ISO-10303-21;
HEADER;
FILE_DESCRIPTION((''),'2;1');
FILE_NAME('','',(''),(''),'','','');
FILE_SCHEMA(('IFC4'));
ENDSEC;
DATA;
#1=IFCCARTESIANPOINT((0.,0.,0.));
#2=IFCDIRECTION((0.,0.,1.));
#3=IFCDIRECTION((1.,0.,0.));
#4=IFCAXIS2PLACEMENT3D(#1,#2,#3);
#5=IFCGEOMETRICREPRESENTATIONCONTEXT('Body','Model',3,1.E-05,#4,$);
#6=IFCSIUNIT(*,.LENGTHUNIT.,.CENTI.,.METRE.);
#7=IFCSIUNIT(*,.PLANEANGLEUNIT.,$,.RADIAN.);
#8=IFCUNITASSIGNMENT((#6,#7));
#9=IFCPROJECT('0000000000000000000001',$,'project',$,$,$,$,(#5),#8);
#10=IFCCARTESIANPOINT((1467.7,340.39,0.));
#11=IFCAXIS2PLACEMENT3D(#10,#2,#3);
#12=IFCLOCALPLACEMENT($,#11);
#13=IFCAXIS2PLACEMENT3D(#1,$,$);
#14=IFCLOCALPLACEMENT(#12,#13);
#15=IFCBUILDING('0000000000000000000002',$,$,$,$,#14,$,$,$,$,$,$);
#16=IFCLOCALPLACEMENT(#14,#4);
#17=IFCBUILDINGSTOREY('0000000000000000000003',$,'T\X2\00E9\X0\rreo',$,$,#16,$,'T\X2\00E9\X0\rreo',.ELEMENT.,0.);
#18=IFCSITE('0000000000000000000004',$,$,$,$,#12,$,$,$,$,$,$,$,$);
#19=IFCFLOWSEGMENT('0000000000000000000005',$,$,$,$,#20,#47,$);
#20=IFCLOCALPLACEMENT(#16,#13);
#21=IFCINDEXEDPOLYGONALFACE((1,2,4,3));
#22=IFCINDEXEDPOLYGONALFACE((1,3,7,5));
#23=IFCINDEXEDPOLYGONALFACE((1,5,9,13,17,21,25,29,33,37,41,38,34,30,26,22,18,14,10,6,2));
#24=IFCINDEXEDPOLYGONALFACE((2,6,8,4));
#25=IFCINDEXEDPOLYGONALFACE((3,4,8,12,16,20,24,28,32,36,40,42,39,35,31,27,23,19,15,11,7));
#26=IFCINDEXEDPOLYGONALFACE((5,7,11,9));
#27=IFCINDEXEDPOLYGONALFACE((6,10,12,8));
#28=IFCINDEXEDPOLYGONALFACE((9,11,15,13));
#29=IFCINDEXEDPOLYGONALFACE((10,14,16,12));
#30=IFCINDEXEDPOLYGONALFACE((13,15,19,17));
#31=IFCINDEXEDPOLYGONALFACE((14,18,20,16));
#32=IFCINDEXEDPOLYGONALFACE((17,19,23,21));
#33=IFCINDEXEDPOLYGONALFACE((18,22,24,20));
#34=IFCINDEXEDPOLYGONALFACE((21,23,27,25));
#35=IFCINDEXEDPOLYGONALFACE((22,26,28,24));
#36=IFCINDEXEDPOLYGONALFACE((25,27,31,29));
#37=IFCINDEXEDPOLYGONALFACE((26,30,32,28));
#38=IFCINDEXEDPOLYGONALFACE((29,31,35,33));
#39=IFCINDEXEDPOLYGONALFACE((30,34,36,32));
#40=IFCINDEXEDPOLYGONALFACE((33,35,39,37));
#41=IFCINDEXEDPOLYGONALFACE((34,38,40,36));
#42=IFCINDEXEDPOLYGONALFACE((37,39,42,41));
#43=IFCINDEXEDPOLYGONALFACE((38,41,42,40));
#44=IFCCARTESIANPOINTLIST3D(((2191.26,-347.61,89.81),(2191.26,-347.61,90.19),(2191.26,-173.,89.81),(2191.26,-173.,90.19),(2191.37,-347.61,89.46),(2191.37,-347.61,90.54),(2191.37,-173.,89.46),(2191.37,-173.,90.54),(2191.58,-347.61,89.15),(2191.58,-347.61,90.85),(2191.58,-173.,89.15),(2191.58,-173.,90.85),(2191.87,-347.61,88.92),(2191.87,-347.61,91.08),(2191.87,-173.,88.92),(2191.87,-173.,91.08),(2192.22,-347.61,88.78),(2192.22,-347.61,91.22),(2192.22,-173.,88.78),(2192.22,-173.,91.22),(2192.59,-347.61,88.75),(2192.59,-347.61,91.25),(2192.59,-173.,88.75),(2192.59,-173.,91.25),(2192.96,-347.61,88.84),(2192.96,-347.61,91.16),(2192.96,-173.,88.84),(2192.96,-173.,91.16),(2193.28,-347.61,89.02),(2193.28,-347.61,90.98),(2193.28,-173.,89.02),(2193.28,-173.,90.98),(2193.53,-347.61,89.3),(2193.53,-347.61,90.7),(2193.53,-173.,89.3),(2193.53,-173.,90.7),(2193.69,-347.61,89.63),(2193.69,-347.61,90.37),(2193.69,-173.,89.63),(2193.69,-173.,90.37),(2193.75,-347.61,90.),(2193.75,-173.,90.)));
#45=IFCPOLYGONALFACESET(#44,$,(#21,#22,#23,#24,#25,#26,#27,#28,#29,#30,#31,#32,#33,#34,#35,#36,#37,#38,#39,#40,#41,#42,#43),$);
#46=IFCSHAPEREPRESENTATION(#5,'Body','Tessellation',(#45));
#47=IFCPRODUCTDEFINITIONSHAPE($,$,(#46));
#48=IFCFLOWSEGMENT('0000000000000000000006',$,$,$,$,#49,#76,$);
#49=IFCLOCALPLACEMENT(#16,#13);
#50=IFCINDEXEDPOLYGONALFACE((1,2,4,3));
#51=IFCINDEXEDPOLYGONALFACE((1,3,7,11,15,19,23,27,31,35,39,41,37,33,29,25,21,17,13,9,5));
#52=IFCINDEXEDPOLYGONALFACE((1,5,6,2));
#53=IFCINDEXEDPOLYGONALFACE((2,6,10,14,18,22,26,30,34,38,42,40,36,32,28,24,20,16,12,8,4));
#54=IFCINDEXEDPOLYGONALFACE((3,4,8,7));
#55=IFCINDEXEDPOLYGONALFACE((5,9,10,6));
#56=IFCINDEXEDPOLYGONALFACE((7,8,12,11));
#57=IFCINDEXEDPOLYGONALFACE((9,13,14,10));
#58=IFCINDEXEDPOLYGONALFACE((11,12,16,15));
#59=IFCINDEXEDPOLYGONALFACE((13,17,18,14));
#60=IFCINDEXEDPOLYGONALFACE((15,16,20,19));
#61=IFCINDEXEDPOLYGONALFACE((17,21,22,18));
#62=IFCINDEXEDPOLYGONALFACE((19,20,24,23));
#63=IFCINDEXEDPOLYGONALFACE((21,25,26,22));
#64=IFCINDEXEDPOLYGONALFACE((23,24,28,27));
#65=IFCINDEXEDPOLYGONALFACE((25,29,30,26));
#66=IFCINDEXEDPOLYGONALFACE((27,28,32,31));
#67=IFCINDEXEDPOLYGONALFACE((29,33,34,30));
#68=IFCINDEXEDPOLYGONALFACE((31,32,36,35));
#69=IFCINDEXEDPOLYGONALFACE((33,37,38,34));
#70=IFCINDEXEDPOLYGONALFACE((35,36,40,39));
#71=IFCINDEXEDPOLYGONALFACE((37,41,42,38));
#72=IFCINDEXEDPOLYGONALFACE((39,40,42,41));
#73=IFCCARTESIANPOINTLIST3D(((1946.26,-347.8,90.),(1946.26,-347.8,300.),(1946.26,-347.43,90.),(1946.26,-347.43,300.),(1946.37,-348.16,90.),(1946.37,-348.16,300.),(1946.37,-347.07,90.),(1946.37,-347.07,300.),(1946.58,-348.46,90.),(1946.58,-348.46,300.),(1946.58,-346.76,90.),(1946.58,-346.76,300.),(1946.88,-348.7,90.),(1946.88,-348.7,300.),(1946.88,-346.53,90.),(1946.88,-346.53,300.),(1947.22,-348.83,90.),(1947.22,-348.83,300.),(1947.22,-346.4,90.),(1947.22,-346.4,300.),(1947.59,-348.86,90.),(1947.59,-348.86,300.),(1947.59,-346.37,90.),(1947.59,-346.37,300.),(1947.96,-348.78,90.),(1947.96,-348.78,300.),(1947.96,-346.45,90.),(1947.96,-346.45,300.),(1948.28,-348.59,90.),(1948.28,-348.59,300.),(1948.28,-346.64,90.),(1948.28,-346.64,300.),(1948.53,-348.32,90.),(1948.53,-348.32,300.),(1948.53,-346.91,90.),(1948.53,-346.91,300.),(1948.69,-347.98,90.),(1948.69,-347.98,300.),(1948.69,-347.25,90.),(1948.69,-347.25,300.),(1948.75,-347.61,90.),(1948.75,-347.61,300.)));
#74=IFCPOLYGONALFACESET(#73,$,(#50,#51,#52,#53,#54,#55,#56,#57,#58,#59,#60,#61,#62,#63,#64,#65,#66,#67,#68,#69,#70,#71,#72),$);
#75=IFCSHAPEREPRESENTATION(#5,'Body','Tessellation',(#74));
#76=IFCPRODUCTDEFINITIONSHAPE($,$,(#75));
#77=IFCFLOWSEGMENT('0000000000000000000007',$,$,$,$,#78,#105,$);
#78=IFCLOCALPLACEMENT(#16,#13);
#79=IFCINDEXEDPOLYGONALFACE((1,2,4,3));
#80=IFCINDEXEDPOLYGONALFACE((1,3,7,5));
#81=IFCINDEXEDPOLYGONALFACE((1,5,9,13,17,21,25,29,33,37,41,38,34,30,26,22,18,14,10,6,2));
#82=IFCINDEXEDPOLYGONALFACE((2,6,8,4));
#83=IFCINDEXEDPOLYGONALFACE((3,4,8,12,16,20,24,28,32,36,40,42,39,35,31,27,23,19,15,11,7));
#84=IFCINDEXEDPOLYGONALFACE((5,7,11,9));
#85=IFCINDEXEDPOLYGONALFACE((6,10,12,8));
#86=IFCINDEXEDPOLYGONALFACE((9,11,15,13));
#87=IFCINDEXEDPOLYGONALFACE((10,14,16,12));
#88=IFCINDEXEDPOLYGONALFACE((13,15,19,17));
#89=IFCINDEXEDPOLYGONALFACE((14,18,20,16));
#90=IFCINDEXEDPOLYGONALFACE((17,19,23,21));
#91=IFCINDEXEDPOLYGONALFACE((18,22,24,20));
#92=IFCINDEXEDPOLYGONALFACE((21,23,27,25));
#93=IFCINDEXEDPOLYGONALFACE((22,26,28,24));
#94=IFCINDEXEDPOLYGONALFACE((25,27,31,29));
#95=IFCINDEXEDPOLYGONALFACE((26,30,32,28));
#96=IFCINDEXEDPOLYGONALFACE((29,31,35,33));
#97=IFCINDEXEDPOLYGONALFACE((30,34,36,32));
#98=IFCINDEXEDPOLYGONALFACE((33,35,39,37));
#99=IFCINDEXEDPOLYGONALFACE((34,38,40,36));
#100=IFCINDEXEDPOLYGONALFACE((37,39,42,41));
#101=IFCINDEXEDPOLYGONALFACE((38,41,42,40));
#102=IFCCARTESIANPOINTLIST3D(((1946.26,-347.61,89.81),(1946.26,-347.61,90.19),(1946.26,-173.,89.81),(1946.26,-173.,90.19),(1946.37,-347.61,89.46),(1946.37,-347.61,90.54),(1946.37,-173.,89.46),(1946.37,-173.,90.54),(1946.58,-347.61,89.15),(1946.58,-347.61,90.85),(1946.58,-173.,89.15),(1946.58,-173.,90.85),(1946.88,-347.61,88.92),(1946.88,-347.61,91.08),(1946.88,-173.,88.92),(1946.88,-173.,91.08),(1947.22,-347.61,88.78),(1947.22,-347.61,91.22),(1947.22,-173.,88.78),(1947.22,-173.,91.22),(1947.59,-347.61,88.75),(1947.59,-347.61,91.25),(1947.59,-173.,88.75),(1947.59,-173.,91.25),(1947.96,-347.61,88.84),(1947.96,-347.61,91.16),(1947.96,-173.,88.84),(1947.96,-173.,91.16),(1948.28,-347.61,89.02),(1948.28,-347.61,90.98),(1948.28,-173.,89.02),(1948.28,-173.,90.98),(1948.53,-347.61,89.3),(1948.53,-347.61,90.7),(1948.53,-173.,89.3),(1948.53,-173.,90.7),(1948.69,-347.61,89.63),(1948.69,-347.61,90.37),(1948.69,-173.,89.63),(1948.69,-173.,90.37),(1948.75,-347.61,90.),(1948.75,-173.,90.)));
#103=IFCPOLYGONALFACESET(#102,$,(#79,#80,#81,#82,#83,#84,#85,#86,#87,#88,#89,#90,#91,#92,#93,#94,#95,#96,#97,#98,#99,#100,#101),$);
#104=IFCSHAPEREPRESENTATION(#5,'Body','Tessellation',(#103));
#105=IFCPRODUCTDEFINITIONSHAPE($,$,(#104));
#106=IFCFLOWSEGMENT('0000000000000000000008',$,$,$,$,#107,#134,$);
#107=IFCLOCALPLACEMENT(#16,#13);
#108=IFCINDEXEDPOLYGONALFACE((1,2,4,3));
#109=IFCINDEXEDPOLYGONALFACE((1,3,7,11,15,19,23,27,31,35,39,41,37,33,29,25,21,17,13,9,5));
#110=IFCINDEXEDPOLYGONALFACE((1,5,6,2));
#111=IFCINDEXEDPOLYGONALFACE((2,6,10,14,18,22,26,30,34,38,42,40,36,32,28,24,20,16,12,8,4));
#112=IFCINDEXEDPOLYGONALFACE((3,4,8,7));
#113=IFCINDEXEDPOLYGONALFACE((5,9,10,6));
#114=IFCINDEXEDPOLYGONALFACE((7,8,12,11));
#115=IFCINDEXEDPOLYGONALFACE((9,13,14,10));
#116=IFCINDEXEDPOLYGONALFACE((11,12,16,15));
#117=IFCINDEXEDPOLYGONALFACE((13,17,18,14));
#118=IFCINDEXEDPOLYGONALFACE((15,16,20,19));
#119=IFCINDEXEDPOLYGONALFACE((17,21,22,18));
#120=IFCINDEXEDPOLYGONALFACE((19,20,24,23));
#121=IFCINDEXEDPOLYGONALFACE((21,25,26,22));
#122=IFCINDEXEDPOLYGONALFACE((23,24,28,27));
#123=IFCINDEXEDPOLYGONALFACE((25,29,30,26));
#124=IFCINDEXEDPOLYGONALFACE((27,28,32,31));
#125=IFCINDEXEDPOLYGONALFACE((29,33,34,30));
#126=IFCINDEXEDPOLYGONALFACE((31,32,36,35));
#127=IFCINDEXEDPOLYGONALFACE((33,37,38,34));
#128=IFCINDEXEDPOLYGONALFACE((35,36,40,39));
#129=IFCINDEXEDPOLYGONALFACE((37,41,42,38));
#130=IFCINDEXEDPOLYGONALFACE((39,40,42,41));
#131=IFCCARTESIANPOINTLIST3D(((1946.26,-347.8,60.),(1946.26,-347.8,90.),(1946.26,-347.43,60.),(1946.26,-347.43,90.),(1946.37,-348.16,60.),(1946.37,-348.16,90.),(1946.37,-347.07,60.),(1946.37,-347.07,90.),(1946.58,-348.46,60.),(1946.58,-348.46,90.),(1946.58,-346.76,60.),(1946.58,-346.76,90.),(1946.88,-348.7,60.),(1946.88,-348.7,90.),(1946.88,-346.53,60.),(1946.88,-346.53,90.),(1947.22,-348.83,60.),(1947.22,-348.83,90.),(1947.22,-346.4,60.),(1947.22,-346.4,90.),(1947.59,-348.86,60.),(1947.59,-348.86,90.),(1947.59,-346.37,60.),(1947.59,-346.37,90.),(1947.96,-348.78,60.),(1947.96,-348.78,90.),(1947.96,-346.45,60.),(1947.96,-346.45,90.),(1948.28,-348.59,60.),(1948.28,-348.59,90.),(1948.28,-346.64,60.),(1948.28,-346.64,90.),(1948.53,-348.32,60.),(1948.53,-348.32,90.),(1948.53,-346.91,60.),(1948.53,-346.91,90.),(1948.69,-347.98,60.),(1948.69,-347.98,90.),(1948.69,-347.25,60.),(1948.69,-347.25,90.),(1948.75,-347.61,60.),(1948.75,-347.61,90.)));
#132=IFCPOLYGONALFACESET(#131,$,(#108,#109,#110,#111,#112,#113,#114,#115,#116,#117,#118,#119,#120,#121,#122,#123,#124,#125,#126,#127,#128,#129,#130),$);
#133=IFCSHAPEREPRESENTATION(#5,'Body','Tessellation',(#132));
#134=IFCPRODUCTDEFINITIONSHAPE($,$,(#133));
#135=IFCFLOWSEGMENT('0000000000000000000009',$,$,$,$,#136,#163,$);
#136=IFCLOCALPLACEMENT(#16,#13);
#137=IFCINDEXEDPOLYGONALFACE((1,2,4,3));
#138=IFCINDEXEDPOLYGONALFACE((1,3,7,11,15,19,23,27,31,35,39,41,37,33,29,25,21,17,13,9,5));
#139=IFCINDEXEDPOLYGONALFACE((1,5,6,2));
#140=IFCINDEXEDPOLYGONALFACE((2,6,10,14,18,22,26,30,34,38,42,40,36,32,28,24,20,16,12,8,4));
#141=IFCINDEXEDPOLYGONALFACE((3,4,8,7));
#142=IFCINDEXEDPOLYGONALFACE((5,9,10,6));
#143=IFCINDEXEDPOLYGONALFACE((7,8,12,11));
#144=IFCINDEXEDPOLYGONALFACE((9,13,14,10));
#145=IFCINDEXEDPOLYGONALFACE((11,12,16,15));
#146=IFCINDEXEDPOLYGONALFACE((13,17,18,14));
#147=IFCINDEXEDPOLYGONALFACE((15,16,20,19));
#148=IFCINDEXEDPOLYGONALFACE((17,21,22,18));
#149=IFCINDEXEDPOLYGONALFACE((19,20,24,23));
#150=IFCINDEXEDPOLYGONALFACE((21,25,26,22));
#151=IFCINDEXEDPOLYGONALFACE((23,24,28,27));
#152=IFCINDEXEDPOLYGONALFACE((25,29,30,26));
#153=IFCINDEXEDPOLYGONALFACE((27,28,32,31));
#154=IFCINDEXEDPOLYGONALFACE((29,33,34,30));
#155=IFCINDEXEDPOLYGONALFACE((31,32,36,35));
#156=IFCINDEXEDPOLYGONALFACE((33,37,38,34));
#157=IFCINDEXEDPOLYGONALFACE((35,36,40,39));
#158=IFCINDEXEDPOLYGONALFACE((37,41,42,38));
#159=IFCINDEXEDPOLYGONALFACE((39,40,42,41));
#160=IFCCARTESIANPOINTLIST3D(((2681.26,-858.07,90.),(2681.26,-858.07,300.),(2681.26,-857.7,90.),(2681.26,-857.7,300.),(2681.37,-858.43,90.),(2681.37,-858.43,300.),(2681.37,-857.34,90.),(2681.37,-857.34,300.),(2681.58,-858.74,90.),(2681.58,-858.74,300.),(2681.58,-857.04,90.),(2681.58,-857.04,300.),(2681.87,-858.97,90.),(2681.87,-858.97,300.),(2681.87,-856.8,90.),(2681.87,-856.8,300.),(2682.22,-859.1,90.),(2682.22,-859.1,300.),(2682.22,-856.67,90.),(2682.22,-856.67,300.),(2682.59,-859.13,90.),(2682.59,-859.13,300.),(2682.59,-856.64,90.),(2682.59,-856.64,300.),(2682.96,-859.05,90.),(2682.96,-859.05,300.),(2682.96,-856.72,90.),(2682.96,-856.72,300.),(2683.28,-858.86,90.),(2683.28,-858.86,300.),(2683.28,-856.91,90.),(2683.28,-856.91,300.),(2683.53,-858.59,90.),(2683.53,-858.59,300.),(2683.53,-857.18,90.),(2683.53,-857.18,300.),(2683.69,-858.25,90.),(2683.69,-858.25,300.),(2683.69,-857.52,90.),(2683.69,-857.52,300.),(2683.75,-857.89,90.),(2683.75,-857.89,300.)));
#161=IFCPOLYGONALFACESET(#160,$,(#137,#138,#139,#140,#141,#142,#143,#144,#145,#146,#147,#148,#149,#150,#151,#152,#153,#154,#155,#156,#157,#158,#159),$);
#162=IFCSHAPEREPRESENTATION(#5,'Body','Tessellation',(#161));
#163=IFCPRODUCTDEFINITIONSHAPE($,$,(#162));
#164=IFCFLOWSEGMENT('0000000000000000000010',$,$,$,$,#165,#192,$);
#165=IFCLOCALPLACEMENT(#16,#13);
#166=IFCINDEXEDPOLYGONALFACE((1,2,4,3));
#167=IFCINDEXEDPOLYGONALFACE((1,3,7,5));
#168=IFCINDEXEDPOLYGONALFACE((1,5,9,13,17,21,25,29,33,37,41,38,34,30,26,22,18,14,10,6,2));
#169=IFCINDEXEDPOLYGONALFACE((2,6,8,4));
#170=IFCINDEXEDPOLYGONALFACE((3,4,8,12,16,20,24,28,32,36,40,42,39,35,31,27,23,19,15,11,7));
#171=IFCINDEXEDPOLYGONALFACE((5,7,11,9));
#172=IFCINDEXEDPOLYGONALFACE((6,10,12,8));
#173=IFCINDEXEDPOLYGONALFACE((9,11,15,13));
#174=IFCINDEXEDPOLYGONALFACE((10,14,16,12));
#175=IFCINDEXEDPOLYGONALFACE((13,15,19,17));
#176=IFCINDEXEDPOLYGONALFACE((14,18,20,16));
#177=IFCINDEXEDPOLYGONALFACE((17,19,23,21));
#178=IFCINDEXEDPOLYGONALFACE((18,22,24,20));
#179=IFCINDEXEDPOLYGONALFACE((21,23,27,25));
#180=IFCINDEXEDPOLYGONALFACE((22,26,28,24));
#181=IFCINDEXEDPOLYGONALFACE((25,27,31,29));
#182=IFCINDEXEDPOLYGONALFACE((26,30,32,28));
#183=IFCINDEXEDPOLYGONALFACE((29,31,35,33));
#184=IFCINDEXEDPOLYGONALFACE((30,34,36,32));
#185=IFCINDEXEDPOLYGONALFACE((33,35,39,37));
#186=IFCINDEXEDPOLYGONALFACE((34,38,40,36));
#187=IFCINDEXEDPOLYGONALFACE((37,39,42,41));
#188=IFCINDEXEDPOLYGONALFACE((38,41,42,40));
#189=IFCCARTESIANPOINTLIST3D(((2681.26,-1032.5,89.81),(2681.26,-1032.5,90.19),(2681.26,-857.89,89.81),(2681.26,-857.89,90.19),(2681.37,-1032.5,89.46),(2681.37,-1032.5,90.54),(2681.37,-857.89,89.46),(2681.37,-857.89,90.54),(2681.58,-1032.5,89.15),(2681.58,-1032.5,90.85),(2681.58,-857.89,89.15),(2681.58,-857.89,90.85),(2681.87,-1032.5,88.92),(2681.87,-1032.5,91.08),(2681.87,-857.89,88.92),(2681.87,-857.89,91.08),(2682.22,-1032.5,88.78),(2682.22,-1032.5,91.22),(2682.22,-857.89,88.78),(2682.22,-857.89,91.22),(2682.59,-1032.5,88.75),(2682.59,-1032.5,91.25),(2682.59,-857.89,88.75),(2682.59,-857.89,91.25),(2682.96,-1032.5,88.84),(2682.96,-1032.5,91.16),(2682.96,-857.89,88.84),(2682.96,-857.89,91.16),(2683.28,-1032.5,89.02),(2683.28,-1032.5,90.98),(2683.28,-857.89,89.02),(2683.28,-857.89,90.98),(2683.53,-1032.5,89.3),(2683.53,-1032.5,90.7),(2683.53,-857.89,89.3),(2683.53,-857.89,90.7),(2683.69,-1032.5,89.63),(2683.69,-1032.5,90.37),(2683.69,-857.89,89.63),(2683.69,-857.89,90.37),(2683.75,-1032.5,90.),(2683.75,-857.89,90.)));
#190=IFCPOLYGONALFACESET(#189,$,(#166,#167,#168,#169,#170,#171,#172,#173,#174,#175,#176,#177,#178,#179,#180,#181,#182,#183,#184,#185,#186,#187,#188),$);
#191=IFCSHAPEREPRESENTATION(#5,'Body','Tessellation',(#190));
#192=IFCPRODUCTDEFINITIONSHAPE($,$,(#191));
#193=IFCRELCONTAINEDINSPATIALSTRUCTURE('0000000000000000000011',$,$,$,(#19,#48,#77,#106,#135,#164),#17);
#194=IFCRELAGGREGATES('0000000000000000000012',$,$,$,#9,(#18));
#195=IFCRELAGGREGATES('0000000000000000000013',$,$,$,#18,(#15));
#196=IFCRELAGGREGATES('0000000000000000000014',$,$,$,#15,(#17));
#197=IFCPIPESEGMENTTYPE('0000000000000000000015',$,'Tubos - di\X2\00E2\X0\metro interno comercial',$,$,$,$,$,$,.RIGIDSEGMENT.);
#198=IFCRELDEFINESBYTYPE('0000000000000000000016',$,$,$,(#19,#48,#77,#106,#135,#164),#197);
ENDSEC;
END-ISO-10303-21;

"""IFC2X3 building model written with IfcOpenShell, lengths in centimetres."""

from ifc_helpers import new_model, si_unit, frame, origin, origin_with_axes, origin_2d_with_axis, place, context, project, spatial, circle, extrude, type_object, element, save


model = new_model("IFC2X3")

# Units and contexts
model_context = context("Model", 3, precision=1e-05, world=origin_with_axes(), identifier="Body")
ifc_project = project(units=[si_unit("LENGTHUNIT", "METRE", prefix="CENTI"), si_unit("PLANEANGLEUNIT", "RADIAN")], contexts=[model_context])

# Site, building, storey
site_placement = place(None, frame((1467.7, 340.39, 0.0), z_axis=(0.0, 0.0, 1.0), x_axis=(1.0, 0.0, 0.0)))
site = spatial("IfcSite", under=ifc_project, at=site_placement)
building_placement = place(site_placement, origin())
building = spatial("IfcBuilding", under=site, at=building_placement)
storey_placement = place(building_placement, origin_with_axes())
storey = spatial("IfcBuildingStorey", under=building, at=storey_placement, Name="Térreo", LongName="Térreo", CompositionType="ELEMENT", Elevation=0.0)

# Flow segments
pipe_segment_type = type_object("IfcPipeSegmentType", Name="Tubos - diâmetro interno comercial", PredefinedType="RIGIDSEGMENT")
flow_segment_1_placement = place(storey_placement, frame((2192.5, -260.31, 91.25), z_axis=(0.0, 0.0, 1.0), x_axis=(1.0, 0.0, 0.0)))
element("IfcFlowSegment", 1, at=flow_segment_1_placement, inside=storey, type_object=pipe_segment_type, context=model_context, shape_type="SolidModel", body=[
    extrude(circle(Radius=1.25, at=origin_2d_with_axis()), frame((0.0, -87.31, -1.25), z_axis=(0.0, 1.0, 0.0), x_axis=(1.0, 0.0, 0.0)), (0.0, 0.0, 1.0), 174.61),
])
flow_segment_2_placement = place(storey_placement, frame((1947.5, -347.61, 300.0), z_axis=(0.0, 0.0, 1.0), x_axis=(1.0, 0.0, 0.0)))
element("IfcFlowSegment", 2, at=flow_segment_2_placement, inside=storey, type_object=pipe_segment_type, context=model_context, shape_type="SolidModel", body=[
    extrude(circle(Radius=1.25, at=origin_2d_with_axis()), frame((0.0, 0.0, 0.0), z_axis=(0.0, 0.0, -1.0), x_axis=(1.0, 0.0, 0.0)), (0.0, 0.0, 1.0), 210.0),
])
flow_segment_3_placement = place(storey_placement, frame((1947.5, -260.31, 91.25), z_axis=(0.0, 0.0, 1.0), x_axis=(1.0, 0.0, 0.0)))
element("IfcFlowSegment", 3, at=flow_segment_3_placement, inside=storey, type_object=pipe_segment_type, context=model_context, shape_type="SolidModel", body=[
    extrude(circle(Radius=1.25, at=origin_2d_with_axis()), frame((0.0, -87.31, -1.25), z_axis=(0.0, 1.0, 0.0), x_axis=(1.0, 0.0, 0.0)), (0.0, 0.0, 1.0), 174.61),
])
flow_segment_4_placement = place(storey_placement, frame((1947.5, -347.61, 90.0), z_axis=(0.0, 0.0, 1.0), x_axis=(1.0, 0.0, 0.0)))
element("IfcFlowSegment", 4, at=flow_segment_4_placement, inside=storey, type_object=pipe_segment_type, context=model_context, shape_type="SolidModel", body=[
    extrude(circle(Radius=1.25, at=origin_2d_with_axis()), frame((0.0, 0.0, 0.0), z_axis=(0.0, 0.0, -1.0), x_axis=(1.0, 0.0, 0.0)), (0.0, 0.0, 1.0), 30.0),
])
flow_segment_5_placement = place(storey_placement, frame((2682.5, -857.89, 300.0), z_axis=(0.0, 0.0, 1.0), x_axis=(1.0, 0.0, 0.0)))
element("IfcFlowSegment", 5, at=flow_segment_5_placement, inside=storey, type_object=pipe_segment_type, context=model_context, shape_type="SolidModel", body=[
    extrude(circle(Radius=1.25, at=origin_2d_with_axis()), frame((0.0, 0.0, 0.0), z_axis=(0.0, 0.0, -1.0), x_axis=(1.0, 0.0, 0.0)), (0.0, 0.0, 1.0), 210.0),
])
flow_segment_6_placement = place(storey_placement, frame((2682.5, -945.19, 91.25), z_axis=(0.0, 0.0, 1.0), x_axis=(1.0, 0.0, 0.0)))
element("IfcFlowSegment", 6, at=flow_segment_6_placement, inside=storey, type_object=pipe_segment_type, context=model_context, shape_type="SolidModel", body=[
    extrude(circle(Radius=1.25, at=origin_2d_with_axis()), frame((0.0, 87.31, -1.25), z_axis=(0.0, -1.0, 0.0), x_axis=(1.0, 0.0, 0.0)), (0.0, 0.0, 1.0), 174.61),
])

save(model, "model.ifc")
